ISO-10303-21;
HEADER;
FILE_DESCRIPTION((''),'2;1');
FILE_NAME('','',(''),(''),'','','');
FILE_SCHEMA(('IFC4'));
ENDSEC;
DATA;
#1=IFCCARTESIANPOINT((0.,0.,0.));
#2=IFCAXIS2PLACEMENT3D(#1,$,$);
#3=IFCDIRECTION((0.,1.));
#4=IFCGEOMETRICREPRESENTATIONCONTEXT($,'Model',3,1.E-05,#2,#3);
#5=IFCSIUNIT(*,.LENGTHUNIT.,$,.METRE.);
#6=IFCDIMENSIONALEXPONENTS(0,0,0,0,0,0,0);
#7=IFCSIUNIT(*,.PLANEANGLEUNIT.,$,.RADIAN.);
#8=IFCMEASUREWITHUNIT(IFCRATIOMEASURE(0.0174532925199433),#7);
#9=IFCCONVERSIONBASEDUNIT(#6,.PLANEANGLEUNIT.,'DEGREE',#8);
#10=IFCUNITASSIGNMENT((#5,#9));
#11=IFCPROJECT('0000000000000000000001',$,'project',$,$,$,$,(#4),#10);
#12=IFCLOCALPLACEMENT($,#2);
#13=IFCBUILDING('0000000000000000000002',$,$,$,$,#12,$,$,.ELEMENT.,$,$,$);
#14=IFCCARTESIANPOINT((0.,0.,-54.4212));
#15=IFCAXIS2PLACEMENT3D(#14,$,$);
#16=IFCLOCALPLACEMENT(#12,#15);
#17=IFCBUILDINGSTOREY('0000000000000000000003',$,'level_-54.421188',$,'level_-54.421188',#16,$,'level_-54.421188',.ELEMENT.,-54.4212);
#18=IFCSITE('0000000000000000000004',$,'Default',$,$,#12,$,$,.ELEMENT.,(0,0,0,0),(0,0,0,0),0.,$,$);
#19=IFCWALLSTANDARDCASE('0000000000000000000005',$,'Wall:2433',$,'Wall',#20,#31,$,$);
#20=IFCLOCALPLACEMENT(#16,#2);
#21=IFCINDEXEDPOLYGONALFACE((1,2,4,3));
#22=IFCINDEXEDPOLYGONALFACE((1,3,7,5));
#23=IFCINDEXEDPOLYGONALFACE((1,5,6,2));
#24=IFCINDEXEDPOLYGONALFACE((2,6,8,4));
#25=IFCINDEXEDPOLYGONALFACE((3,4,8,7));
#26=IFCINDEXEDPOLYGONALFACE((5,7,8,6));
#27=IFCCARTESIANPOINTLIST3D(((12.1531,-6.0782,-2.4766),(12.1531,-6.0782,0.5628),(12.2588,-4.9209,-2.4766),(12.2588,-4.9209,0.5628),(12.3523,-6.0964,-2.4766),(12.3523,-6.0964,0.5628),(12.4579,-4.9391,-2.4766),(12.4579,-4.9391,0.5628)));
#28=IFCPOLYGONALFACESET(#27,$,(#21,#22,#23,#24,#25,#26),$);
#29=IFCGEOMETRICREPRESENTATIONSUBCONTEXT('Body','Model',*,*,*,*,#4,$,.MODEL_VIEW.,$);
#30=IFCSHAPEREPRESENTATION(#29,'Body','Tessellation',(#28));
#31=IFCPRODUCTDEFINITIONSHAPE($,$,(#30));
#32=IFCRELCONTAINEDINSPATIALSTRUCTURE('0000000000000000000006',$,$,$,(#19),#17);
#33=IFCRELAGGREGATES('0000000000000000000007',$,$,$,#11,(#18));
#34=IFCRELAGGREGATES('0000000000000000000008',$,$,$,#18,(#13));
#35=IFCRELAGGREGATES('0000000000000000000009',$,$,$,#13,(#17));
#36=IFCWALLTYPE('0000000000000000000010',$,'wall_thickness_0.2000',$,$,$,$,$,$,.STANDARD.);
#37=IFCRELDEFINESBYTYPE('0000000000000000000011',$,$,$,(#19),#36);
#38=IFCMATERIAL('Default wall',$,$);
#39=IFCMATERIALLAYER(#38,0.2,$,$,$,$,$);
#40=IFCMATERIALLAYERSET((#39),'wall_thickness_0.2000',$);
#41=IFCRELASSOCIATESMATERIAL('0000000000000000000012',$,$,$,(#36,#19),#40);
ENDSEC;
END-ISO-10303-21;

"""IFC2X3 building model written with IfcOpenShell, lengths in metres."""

from ifc_helpers import new_model, entity, si_unit, converted_unit, direction, frame, origin, place, context, subcontext, project, spatial, polyline, outline, extrude, material, layer, layer_set, layer_usage, type_object, element, save


model = new_model("IFC2X3")

# Units and contexts
model_context = context("Model", 3, precision=1e-05, world=origin(), true_north=direction((0.0, 1.0)))
body_context = subcontext(model_context, "Body", "Model", "MODEL_VIEW")
ifc_project = project(units=[si_unit("LENGTHUNIT", "METRE"), converted_unit("PLANEANGLEUNIT", "DEGREE", entity("IfcRatioMeasure", 0.0174532925199433), si_unit("PLANEANGLEUNIT", "RADIAN"), dimensions=[0, 0, 0, 0, 0, 0, 0])], contexts=[model_context])

# Site, building, storey
placement_1 = place(None, origin())
site = spatial("IfcSite", under=ifc_project, at=placement_1, Name="Default", CompositionType="ELEMENT", RefLatitude=(0, 0, 0, 0), RefLongitude=(0, 0, 0, 0), RefElevation=0.0)
building = spatial("IfcBuilding", under=site, at=placement_1, CompositionType="ELEMENT")
storey_placement = place(placement_1, frame((0.0, 0.0, -54.4212)))
storey = spatial("IfcBuildingStorey", under=building, at=storey_placement, Name="level_-54.421188", ObjectType="level_-54.421188", LongName="level_-54.421188", CompositionType="ELEMENT", Elevation=-54.4212)

# Shared definitions
ifc_material = material(Name="Default wall")
ifc_layer = layer(ifc_material, 0.2)
ifc_layer_set = layer_set([ifc_layer], Name="wall_thickness_0.2000")
ifc_layer_usage = layer_usage(ifc_layer_set, "AXIS2", "POSITIVE", -0.1)
wall_type = type_object("IfcWallType", Name="wall_thickness_0.2000", PredefinedType="STANDARD", material=ifc_layer_set)

# Wall
placement_2 = place(placement_1, frame((0.0, 0.0, -56.8978)))
wall_1_placement = place(placement_2, frame((12.3583, -4.93, 0.0), z_axis=(0.0, 0.0, 1.0), x_axis=(-0.090892, -0.995861, 0.0)))
element("IfcWallStandardCase", 1, at=wall_1_placement, inside=storey, type_object=wall_type, material=ifc_layer_usage, Name="Wall:2433", ObjectType="Wall", context=body_context, shape_type="SweptSolid", body=[
    extrude(outline(polyline([(1.1621, -0.1), (1.1621, 0.1), (0.0, 0.1), (0.0, -0.1), (1.1621, -0.1)])), origin(), (0.0, 0.0, 1.0), 3.0394),
])

save(model, "model.ifc")
